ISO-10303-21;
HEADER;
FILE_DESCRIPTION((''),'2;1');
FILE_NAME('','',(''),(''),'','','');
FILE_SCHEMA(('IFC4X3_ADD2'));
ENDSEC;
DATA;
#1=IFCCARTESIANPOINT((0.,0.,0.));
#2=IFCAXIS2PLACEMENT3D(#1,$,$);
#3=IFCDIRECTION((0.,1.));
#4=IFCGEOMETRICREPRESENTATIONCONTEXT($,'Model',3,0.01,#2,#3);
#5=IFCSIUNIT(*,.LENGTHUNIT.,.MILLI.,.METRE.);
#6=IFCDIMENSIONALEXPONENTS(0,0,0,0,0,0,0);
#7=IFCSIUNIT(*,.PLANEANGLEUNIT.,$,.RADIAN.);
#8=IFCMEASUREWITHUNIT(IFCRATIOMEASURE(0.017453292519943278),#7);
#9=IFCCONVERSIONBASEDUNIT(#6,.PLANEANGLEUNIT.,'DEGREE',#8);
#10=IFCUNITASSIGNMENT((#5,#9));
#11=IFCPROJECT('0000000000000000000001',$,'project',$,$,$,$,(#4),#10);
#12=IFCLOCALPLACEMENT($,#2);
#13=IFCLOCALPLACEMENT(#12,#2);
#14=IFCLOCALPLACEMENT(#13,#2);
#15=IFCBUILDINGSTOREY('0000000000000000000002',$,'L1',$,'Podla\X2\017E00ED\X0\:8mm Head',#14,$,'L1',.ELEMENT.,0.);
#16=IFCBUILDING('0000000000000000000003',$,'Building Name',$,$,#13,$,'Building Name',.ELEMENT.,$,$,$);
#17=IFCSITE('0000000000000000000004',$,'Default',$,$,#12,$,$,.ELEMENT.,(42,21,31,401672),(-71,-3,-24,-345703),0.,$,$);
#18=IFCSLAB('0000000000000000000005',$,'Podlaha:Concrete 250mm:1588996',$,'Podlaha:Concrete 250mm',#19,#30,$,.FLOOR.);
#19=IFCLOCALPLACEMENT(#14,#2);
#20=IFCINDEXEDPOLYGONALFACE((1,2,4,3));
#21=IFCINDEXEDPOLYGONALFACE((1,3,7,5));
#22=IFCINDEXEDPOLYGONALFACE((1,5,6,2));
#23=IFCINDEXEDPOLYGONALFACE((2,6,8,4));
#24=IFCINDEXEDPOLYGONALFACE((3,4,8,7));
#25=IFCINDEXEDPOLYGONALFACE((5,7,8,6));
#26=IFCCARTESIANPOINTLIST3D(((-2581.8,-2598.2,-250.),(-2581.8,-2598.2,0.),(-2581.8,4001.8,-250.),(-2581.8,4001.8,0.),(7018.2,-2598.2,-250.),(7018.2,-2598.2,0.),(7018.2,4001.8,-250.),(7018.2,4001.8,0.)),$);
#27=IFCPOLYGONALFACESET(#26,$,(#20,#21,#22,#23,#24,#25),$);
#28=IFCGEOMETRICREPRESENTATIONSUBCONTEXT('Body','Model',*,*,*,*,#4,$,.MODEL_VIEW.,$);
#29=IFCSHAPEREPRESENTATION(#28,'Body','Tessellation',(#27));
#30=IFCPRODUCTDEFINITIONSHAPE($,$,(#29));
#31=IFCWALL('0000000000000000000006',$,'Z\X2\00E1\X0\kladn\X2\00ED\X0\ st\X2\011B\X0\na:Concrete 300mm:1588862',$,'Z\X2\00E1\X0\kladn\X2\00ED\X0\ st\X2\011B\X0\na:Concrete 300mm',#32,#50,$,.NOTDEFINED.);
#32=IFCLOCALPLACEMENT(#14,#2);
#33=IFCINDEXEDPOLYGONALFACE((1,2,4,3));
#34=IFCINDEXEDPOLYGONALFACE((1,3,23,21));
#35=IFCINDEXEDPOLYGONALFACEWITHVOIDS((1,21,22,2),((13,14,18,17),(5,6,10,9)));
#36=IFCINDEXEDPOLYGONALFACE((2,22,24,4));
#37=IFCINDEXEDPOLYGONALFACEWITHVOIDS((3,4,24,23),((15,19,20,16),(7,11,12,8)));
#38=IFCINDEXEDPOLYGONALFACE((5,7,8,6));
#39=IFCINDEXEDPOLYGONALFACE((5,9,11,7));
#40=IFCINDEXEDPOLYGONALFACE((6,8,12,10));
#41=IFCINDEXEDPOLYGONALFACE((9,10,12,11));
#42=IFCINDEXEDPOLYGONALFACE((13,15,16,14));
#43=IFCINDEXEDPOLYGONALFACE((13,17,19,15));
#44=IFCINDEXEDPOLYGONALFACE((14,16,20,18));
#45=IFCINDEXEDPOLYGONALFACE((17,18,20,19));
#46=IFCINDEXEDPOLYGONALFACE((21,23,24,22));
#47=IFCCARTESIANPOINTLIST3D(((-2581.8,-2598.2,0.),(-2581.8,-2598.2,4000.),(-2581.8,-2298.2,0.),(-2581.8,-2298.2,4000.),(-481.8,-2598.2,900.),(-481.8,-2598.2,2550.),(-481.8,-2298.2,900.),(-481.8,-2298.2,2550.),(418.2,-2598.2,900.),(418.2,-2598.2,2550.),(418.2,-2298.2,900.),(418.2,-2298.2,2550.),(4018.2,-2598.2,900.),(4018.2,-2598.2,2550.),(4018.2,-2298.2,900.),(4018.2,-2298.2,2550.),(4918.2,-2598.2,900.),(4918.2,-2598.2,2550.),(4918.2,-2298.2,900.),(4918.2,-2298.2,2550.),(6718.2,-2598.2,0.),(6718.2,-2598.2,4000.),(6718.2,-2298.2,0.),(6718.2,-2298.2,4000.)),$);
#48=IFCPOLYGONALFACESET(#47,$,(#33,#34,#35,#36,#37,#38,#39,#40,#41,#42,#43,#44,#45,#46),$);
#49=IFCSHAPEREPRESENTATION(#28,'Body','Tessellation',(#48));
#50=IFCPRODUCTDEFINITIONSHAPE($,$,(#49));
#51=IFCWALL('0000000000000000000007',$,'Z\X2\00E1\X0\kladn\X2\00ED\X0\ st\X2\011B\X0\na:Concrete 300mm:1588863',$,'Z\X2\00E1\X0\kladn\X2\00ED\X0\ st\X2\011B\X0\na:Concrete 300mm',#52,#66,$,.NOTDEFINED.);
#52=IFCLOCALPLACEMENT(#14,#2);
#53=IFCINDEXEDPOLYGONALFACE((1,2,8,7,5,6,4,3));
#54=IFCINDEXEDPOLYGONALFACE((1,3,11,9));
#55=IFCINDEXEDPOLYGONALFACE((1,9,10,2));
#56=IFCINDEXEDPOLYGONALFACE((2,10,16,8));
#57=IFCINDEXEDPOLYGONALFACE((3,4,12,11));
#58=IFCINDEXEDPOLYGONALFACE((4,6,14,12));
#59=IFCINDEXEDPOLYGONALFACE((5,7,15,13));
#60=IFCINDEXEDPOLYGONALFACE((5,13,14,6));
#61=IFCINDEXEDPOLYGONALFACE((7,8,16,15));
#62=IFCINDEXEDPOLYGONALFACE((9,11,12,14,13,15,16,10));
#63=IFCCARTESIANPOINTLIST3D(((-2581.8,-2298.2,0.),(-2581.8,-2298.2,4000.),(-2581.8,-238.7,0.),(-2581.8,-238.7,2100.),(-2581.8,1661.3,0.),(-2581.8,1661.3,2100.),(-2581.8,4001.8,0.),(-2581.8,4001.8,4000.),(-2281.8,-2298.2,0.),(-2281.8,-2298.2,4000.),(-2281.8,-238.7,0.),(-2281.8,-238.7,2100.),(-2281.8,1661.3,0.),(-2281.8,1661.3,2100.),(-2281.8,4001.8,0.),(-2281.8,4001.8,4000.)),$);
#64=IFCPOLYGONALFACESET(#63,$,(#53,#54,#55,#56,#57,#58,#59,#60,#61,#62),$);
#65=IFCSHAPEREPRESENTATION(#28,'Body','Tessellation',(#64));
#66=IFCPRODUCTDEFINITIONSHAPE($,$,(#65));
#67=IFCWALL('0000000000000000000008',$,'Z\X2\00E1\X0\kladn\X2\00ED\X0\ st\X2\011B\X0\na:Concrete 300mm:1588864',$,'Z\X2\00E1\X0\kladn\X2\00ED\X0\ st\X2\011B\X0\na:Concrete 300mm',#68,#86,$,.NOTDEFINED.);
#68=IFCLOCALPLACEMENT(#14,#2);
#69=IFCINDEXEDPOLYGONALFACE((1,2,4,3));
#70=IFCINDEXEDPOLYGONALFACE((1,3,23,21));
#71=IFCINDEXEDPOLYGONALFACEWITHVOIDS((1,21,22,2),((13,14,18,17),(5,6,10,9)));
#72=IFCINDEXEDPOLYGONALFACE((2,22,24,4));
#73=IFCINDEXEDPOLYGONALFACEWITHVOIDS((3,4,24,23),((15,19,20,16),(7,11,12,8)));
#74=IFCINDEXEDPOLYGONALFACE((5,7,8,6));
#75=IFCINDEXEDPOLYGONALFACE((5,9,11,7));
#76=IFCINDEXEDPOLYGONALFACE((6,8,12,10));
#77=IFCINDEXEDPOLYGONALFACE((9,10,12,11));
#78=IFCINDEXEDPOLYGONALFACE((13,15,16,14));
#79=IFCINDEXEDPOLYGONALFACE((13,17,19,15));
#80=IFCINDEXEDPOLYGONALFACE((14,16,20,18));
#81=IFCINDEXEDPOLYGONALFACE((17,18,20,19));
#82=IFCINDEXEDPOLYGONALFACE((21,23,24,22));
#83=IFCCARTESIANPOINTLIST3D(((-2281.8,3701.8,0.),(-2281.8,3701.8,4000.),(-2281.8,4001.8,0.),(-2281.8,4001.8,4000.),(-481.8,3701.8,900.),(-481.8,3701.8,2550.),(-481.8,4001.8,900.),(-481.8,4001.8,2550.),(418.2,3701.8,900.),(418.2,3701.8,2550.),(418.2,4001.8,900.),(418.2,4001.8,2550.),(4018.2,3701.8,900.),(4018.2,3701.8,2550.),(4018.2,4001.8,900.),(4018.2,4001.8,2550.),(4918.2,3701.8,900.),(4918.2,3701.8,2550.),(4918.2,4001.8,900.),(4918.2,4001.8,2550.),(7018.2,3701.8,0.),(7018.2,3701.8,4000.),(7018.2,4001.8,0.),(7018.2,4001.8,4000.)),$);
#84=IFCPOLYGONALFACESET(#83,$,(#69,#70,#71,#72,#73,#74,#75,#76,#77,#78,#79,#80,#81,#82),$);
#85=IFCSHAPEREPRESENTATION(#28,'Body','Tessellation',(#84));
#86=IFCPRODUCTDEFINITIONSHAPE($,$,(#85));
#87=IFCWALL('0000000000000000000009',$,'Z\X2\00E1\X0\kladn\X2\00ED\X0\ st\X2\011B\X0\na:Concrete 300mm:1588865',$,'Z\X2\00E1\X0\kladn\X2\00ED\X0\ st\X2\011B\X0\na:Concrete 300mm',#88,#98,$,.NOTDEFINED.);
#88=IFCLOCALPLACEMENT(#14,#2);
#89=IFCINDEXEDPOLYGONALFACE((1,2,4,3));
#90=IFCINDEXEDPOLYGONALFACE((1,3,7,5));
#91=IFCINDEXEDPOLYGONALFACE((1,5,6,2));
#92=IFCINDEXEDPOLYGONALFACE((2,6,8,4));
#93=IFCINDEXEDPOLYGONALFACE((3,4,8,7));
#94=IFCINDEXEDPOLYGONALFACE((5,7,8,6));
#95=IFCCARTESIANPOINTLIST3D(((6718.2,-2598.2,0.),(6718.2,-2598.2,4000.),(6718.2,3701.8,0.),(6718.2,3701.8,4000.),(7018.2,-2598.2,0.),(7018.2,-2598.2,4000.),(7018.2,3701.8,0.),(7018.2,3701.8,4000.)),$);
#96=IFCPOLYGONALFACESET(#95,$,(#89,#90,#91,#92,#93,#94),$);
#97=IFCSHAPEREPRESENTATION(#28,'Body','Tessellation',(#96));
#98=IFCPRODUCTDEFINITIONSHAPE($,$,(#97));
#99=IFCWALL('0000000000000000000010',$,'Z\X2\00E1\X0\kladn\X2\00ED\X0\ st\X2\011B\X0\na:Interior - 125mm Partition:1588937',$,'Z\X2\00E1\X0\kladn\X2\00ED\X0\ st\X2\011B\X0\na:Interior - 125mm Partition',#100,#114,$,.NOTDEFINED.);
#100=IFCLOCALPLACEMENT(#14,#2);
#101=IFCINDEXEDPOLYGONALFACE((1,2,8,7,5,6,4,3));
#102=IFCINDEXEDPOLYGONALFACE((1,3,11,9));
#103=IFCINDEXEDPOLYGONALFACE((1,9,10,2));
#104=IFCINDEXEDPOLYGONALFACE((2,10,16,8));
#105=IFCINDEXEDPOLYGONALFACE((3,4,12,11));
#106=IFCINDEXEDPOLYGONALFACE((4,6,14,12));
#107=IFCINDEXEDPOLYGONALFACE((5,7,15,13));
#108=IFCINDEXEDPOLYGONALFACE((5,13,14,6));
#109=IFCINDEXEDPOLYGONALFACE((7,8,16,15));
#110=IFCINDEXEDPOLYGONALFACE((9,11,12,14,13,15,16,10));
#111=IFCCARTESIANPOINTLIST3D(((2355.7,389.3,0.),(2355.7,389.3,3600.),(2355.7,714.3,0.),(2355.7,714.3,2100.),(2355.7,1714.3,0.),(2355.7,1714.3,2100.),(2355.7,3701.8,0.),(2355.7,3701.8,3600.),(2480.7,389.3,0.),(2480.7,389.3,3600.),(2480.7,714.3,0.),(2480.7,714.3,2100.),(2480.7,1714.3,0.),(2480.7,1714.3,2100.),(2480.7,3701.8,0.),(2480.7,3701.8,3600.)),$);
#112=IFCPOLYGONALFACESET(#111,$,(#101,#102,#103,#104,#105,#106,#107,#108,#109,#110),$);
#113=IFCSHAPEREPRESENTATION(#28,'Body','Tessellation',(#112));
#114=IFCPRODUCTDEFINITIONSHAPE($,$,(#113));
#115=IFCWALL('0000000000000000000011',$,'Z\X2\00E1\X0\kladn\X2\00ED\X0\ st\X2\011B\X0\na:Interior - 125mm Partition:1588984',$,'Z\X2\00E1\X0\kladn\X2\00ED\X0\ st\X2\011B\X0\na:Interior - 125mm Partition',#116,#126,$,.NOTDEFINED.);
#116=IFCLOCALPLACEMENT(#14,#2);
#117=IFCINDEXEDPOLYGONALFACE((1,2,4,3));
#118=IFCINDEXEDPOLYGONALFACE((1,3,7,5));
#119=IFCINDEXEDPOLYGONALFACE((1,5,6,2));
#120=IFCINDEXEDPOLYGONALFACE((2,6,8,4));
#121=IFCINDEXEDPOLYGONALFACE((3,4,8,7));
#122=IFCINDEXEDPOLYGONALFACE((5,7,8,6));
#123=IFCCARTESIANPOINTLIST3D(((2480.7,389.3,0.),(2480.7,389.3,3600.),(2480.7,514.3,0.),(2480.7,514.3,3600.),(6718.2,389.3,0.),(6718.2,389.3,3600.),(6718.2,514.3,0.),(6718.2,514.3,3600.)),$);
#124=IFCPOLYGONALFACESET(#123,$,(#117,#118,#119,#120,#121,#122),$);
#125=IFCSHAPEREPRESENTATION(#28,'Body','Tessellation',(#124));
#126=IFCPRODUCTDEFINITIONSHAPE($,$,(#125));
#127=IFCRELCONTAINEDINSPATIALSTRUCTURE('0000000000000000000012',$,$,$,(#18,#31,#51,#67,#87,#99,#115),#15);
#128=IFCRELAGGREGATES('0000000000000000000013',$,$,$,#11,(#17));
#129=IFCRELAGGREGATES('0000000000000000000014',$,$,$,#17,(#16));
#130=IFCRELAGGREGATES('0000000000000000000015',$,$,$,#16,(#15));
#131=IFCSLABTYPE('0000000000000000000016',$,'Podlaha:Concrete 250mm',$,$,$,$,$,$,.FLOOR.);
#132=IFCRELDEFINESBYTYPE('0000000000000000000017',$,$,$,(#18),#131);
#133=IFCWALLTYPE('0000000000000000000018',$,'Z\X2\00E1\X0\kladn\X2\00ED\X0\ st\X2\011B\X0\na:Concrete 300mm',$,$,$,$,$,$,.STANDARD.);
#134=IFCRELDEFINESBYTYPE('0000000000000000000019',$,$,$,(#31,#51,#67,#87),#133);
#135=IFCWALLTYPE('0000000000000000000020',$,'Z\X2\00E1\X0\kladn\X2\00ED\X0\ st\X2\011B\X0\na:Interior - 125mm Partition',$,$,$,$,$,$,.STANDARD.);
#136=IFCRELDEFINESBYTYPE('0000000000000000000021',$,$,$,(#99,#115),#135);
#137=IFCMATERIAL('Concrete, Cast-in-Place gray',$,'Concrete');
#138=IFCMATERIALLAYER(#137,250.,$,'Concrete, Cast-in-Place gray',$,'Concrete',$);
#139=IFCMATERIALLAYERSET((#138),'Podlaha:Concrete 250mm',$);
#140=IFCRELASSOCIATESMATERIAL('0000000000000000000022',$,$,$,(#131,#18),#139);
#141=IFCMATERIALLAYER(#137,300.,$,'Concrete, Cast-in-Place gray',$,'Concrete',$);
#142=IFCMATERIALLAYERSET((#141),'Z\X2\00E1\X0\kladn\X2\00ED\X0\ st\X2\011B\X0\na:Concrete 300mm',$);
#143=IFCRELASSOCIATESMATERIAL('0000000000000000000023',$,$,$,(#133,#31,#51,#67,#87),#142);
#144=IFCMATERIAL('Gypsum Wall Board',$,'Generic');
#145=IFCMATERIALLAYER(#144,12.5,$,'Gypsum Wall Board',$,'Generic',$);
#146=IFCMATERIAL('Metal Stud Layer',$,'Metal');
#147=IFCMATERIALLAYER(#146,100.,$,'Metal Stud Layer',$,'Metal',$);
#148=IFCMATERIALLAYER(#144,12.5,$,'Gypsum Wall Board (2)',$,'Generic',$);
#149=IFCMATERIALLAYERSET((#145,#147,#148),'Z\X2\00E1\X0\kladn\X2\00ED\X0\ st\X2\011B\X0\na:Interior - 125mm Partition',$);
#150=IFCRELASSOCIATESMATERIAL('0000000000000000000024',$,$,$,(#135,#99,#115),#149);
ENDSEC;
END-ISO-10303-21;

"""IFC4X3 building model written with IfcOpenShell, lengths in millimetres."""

from ifc_helpers import new_model, entity, si_unit, converted_unit, direction, frame, frame_2d, origin, place, context, subcontext, project, spatial, rectangle, extrude, material, layer, layer_set, layer_usage, type_object, element, save


model = new_model("IFC4X3")

# Units and contexts
model_context = context("Model", 3, precision=0.01, world=origin(), true_north=direction((0.0, 1.0)))
body_context = subcontext(model_context, "Body", "Model", "MODEL_VIEW")
ifc_project = project(units=[si_unit("LENGTHUNIT", "METRE", prefix="MILLI"), converted_unit("PLANEANGLEUNIT", "DEGREE", entity("IfcRatioMeasure", 0.017453292519943278), si_unit("PLANEANGLEUNIT", "RADIAN"), dimensions=[0, 0, 0, 0, 0, 0, 0])], contexts=[model_context])

# Site, building, storey
site_placement = place(None, origin())
site = spatial("IfcSite", under=ifc_project, at=site_placement, Name="Default", CompositionType="ELEMENT", RefLatitude=(42, 21, 31, 401672), RefLongitude=(-71, -3, -24, -345703), RefElevation=0.0)
building_placement = place(site_placement, origin())
building = spatial("IfcBuilding", under=site, at=building_placement, Name="Building Name", LongName="Building Name", CompositionType="ELEMENT")
storey_placement = place(building_placement, origin())
storey = spatial("IfcBuildingStorey", under=building, at=storey_placement, Name="L1", ObjectType="Podlaží:8mm Head", LongName="L1", CompositionType="ELEMENT", Elevation=0.0)

# Slab
ifc_material_1 = material(Name="Concrete, Cast-in-Place gray", Category="Concrete")
ifc_layer_1 = layer(ifc_material_1, 250.0, Name="Concrete, Cast-in-Place gray", Category="Concrete")
ifc_layer_set_1 = layer_set([ifc_layer_1], Name="Podlaha:Concrete 250mm")
ifc_layer_usage = layer_usage(ifc_layer_set_1, "AXIS3", "POSITIVE", 0.0)
slab_type = type_object("IfcSlabType", Name="Podlaha:Concrete 250mm", PredefinedType="FLOOR", material=ifc_layer_set_1)
slab_placement = place(storey_placement, origin())
element("IfcSlab", 1, at=slab_placement, inside=storey, type_object=slab_type, material=ifc_layer_usage, Name="Podlaha:Concrete 250mm:1588996", ObjectType="Podlaha:Concrete 250mm", PredefinedType="FLOOR", context=body_context, shape_type="SweptSolid", body=[
    extrude(rectangle(XDim=6600.0, YDim=9600.0, at=frame_2d((0.0, 0.0), x_axis=(1.0, 0.0))), frame((2218.2, 701.8, 0.0), z_axis=(0.0, 0.0, -1.0), x_axis=(0.0, 1.0, 0.0)), (0.0, 0.0, 1.0), 250.0),
])

# Wall, openings
ifc_layer_2 = layer(ifc_material_1, 300.0, Name="Concrete, Cast-in-Place gray", Category="Concrete")
ifc_layer_set_2 = layer_set([ifc_layer_2], Name="Základní stěna:Concrete 300mm")
wall_type_1 = type_object("IfcWallType", Name="Základní stěna:Concrete 300mm", PredefinedType="STANDARD", material=ifc_layer_set_2)
wall_1_placement = place(storey_placement, frame((-2581.8, -2448.2, 0.0)))
wall_1 = element("IfcWall", 2, at=wall_1_placement, inside=storey, type_object=wall_type_1, material=ifc_layer_set_2, Name="Základní stěna:Concrete 300mm:1588862", ObjectType="Základní stěna:Concrete 300mm", PredefinedType="NOTDEFINED", context=body_context, shape_type="SweptSolid", body=[
    extrude(rectangle(XDim=9300.0, YDim=300.0, at=frame_2d((4650.0, 0.0), x_axis=(-1.0, 0.0))), origin(), (0.0, 0.0, 1.0), 4000.0),
])
opening_1_placement = place(wall_1_placement, frame((3000.0, 150.0, 900.0)))
element("IfcOpeningElement", 3, at=opening_1_placement, cuts=wall_1, PredefinedType="OPENING", context=body_context, shape_type="SweptSolid", body=[
    extrude(rectangle(XDim=1650.0, YDim=900.0, at=frame_2d((825.0, 450.0), x_axis=(-1.0, 0.0))), frame((0.0, 0.0, 0.0), z_axis=(0.0, -1.0, 0.0), x_axis=(0.0, 0.0, 1.0)), (0.0, 0.0, 1.0), 300.0),
])
opening_2_placement = place(wall_1_placement, frame((7500.0, 150.0, 900.0)))
element("IfcOpeningElement", 4, at=opening_2_placement, cuts=wall_1, PredefinedType="OPENING", context=body_context, shape_type="SweptSolid", body=[
    extrude(rectangle(XDim=1650.0, YDim=900.0, at=frame_2d((825.0, 450.0), x_axis=(-1.0, 0.0))), frame((0.0, 0.0, 0.0), z_axis=(0.0, -1.0, 0.0), x_axis=(0.0, 0.0, 1.0)), (0.0, 0.0, 1.0), 300.0),
])

# Wall, opening
wall_2_placement = place(storey_placement, frame((-2431.8, 4001.8, 0.0), z_axis=(0.0, 0.0, 1.0), x_axis=(0.0, -1.0, 0.0)))
wall_2 = element("IfcWall", 5, at=wall_2_placement, inside=storey, type_object=wall_type_1, material=ifc_layer_set_2, Name="Základní stěna:Concrete 300mm:1588863", ObjectType="Základní stěna:Concrete 300mm", PredefinedType="NOTDEFINED", context=body_context, shape_type="SweptSolid", body=[
    extrude(rectangle(XDim=6300.0, YDim=300.0, at=frame_2d((3150.0, 0.0), x_axis=(1.0, 0.0))), origin(), (0.0, 0.0, 1.0), 4000.0),
])
opening_3_placement = place(wall_2_placement, frame((2340.5, -150.0, 0.0)))
element("IfcOpeningElement", 6, at=opening_3_placement, cuts=wall_2, PredefinedType="OPENING", context=body_context, shape_type="SweptSolid", body=[
    extrude(rectangle(XDim=2100.0, YDim=1900.0, at=frame_2d((1050.0, 950.0), x_axis=(1.0, 0.0))), frame((0.0, 0.0, 0.0), z_axis=(0.0, 1.0, 0.0), x_axis=(0.0, 0.0, 1.0)), (0.0, 0.0, 1.0), 300.0),
])

# Wall, openings
wall_3_placement = place(storey_placement, frame((7018.2, 3851.8, 0.0), z_axis=(0.0, 0.0, 1.0), x_axis=(-1.0, 0.0, 0.0)))
wall_3 = element("IfcWall", 7, at=wall_3_placement, inside=storey, type_object=wall_type_1, material=ifc_layer_set_2, Name="Základní stěna:Concrete 300mm:1588864", ObjectType="Základní stěna:Concrete 300mm", PredefinedType="NOTDEFINED", context=body_context, shape_type="SweptSolid", body=[
    extrude(rectangle(XDim=9300.0, YDim=300.0, at=frame_2d((4650.0, 0.0), x_axis=(-1.0, 0.0))), origin(), (0.0, 0.0, 1.0), 4000.0),
])
opening_4_placement = place(wall_3_placement, frame((7500.0, 150.0, 900.0)))
element("IfcOpeningElement", 8, at=opening_4_placement, cuts=wall_3, PredefinedType="OPENING", context=body_context, shape_type="SweptSolid", body=[
    extrude(rectangle(XDim=1650.0, YDim=900.0, at=frame_2d((825.0, 450.0), x_axis=(-1.0, 0.0))), frame((0.0, 0.0, 0.0), z_axis=(0.0, -1.0, 0.0), x_axis=(0.0, 0.0, 1.0)), (0.0, 0.0, 1.0), 300.0),
])
opening_5_placement = place(wall_3_placement, frame((3000.0, 150.0, 900.0)))
element("IfcOpeningElement", 9, at=opening_5_placement, cuts=wall_3, PredefinedType="OPENING", context=body_context, shape_type="SweptSolid", body=[
    extrude(rectangle(XDim=1650.0, YDim=900.0, at=frame_2d((825.0, 450.0), x_axis=(-1.0, 0.0))), frame((0.0, 0.0, 0.0), z_axis=(0.0, -1.0, 0.0), x_axis=(0.0, 0.0, 1.0)), (0.0, 0.0, 1.0), 300.0),
])

# Wall
wall_4_placement = place(storey_placement, frame((6868.2, -2598.2, 0.0), z_axis=(0.0, 0.0, 1.0), x_axis=(0.0, 1.0, 0.0)))
element("IfcWall", 10, at=wall_4_placement, inside=storey, type_object=wall_type_1, material=ifc_layer_set_2, Name="Základní stěna:Concrete 300mm:1588865", ObjectType="Základní stěna:Concrete 300mm", PredefinedType="NOTDEFINED", context=body_context, shape_type="SweptSolid", body=[
    extrude(rectangle(XDim=6300.0, YDim=300.0, at=frame_2d((3150.0, 0.0), x_axis=(-1.0, 0.0))), origin(), (0.0, 0.0, 1.0), 4000.0),
])

# Wall, opening
ifc_material_2 = material(Name="Gypsum Wall Board", Category="Generic")
ifc_layer_3 = layer(ifc_material_2, 12.5, Name="Gypsum Wall Board", Category="Generic")
ifc_material_3 = material(Name="Metal Stud Layer", Category="Metal")
ifc_layer_4 = layer(ifc_material_3, 100.0, Name="Metal Stud Layer", Category="Metal")
ifc_layer_5 = layer(ifc_material_2, 12.5, Name="Gypsum Wall Board (2)", Category="Generic")
ifc_layer_set_3 = layer_set([ifc_layer_3, ifc_layer_4, ifc_layer_5], Name="Základní stěna:Interior - 125mm Partition")
wall_type_2 = type_object("IfcWallType", Name="Základní stěna:Interior - 125mm Partition", PredefinedType="STANDARD", material=ifc_layer_set_3)
wall_5_placement = place(storey_placement, frame((2418.2, 3701.8, 0.0), z_axis=(0.0, 0.0, 1.0), x_axis=(0.0, -1.0, 0.0)))
wall_5 = element("IfcWall", 11, at=wall_5_placement, inside=storey, type_object=wall_type_2, material=ifc_layer_set_3, Name="Základní stěna:Interior - 125mm Partition:1588937", ObjectType="Základní stěna:Interior - 125mm Partition", PredefinedType="NOTDEFINED", context=body_context, shape_type="SweptSolid", body=[
    extrude(rectangle(XDim=3312.5, YDim=125.0, at=frame_2d((1656.2, 0.0), x_axis=(1.0, 0.0))), origin(), (0.0, 0.0, 1.0), 3600.0),
])
opening_6_placement = place(wall_5_placement, frame((1987.5, -62.5, 0.0)))
element("IfcOpeningElement", 12, at=opening_6_placement, cuts=wall_5, PredefinedType="OPENING", context=body_context, shape_type="SweptSolid", body=[
    extrude(rectangle(XDim=2100.0, YDim=1000.0, at=frame_2d((1050.0, 500.0), x_axis=(1.0, 0.0))), frame((0.0, 0.0, 0.0), z_axis=(0.0, 1.0, 0.0), x_axis=(0.0, 0.0, 1.0)), (0.0, 0.0, 1.0), 125.0),
])

# Wall
wall_6_placement = place(storey_placement, frame((2480.7, 451.8, 0.0)))
element("IfcWall", 13, at=wall_6_placement, inside=storey, type_object=wall_type_2, material=ifc_layer_set_3, Name="Základní stěna:Interior - 125mm Partition:1588984", ObjectType="Základní stěna:Interior - 125mm Partition", PredefinedType="NOTDEFINED", context=body_context, shape_type="SweptSolid", body=[
    extrude(rectangle(XDim=4237.5, YDim=125.0, at=frame_2d((2118.8, 0.0), x_axis=(-1.0, 0.0))), origin(), (0.0, 0.0, 1.0), 3600.0),
])

save(model, "model.ifc")
